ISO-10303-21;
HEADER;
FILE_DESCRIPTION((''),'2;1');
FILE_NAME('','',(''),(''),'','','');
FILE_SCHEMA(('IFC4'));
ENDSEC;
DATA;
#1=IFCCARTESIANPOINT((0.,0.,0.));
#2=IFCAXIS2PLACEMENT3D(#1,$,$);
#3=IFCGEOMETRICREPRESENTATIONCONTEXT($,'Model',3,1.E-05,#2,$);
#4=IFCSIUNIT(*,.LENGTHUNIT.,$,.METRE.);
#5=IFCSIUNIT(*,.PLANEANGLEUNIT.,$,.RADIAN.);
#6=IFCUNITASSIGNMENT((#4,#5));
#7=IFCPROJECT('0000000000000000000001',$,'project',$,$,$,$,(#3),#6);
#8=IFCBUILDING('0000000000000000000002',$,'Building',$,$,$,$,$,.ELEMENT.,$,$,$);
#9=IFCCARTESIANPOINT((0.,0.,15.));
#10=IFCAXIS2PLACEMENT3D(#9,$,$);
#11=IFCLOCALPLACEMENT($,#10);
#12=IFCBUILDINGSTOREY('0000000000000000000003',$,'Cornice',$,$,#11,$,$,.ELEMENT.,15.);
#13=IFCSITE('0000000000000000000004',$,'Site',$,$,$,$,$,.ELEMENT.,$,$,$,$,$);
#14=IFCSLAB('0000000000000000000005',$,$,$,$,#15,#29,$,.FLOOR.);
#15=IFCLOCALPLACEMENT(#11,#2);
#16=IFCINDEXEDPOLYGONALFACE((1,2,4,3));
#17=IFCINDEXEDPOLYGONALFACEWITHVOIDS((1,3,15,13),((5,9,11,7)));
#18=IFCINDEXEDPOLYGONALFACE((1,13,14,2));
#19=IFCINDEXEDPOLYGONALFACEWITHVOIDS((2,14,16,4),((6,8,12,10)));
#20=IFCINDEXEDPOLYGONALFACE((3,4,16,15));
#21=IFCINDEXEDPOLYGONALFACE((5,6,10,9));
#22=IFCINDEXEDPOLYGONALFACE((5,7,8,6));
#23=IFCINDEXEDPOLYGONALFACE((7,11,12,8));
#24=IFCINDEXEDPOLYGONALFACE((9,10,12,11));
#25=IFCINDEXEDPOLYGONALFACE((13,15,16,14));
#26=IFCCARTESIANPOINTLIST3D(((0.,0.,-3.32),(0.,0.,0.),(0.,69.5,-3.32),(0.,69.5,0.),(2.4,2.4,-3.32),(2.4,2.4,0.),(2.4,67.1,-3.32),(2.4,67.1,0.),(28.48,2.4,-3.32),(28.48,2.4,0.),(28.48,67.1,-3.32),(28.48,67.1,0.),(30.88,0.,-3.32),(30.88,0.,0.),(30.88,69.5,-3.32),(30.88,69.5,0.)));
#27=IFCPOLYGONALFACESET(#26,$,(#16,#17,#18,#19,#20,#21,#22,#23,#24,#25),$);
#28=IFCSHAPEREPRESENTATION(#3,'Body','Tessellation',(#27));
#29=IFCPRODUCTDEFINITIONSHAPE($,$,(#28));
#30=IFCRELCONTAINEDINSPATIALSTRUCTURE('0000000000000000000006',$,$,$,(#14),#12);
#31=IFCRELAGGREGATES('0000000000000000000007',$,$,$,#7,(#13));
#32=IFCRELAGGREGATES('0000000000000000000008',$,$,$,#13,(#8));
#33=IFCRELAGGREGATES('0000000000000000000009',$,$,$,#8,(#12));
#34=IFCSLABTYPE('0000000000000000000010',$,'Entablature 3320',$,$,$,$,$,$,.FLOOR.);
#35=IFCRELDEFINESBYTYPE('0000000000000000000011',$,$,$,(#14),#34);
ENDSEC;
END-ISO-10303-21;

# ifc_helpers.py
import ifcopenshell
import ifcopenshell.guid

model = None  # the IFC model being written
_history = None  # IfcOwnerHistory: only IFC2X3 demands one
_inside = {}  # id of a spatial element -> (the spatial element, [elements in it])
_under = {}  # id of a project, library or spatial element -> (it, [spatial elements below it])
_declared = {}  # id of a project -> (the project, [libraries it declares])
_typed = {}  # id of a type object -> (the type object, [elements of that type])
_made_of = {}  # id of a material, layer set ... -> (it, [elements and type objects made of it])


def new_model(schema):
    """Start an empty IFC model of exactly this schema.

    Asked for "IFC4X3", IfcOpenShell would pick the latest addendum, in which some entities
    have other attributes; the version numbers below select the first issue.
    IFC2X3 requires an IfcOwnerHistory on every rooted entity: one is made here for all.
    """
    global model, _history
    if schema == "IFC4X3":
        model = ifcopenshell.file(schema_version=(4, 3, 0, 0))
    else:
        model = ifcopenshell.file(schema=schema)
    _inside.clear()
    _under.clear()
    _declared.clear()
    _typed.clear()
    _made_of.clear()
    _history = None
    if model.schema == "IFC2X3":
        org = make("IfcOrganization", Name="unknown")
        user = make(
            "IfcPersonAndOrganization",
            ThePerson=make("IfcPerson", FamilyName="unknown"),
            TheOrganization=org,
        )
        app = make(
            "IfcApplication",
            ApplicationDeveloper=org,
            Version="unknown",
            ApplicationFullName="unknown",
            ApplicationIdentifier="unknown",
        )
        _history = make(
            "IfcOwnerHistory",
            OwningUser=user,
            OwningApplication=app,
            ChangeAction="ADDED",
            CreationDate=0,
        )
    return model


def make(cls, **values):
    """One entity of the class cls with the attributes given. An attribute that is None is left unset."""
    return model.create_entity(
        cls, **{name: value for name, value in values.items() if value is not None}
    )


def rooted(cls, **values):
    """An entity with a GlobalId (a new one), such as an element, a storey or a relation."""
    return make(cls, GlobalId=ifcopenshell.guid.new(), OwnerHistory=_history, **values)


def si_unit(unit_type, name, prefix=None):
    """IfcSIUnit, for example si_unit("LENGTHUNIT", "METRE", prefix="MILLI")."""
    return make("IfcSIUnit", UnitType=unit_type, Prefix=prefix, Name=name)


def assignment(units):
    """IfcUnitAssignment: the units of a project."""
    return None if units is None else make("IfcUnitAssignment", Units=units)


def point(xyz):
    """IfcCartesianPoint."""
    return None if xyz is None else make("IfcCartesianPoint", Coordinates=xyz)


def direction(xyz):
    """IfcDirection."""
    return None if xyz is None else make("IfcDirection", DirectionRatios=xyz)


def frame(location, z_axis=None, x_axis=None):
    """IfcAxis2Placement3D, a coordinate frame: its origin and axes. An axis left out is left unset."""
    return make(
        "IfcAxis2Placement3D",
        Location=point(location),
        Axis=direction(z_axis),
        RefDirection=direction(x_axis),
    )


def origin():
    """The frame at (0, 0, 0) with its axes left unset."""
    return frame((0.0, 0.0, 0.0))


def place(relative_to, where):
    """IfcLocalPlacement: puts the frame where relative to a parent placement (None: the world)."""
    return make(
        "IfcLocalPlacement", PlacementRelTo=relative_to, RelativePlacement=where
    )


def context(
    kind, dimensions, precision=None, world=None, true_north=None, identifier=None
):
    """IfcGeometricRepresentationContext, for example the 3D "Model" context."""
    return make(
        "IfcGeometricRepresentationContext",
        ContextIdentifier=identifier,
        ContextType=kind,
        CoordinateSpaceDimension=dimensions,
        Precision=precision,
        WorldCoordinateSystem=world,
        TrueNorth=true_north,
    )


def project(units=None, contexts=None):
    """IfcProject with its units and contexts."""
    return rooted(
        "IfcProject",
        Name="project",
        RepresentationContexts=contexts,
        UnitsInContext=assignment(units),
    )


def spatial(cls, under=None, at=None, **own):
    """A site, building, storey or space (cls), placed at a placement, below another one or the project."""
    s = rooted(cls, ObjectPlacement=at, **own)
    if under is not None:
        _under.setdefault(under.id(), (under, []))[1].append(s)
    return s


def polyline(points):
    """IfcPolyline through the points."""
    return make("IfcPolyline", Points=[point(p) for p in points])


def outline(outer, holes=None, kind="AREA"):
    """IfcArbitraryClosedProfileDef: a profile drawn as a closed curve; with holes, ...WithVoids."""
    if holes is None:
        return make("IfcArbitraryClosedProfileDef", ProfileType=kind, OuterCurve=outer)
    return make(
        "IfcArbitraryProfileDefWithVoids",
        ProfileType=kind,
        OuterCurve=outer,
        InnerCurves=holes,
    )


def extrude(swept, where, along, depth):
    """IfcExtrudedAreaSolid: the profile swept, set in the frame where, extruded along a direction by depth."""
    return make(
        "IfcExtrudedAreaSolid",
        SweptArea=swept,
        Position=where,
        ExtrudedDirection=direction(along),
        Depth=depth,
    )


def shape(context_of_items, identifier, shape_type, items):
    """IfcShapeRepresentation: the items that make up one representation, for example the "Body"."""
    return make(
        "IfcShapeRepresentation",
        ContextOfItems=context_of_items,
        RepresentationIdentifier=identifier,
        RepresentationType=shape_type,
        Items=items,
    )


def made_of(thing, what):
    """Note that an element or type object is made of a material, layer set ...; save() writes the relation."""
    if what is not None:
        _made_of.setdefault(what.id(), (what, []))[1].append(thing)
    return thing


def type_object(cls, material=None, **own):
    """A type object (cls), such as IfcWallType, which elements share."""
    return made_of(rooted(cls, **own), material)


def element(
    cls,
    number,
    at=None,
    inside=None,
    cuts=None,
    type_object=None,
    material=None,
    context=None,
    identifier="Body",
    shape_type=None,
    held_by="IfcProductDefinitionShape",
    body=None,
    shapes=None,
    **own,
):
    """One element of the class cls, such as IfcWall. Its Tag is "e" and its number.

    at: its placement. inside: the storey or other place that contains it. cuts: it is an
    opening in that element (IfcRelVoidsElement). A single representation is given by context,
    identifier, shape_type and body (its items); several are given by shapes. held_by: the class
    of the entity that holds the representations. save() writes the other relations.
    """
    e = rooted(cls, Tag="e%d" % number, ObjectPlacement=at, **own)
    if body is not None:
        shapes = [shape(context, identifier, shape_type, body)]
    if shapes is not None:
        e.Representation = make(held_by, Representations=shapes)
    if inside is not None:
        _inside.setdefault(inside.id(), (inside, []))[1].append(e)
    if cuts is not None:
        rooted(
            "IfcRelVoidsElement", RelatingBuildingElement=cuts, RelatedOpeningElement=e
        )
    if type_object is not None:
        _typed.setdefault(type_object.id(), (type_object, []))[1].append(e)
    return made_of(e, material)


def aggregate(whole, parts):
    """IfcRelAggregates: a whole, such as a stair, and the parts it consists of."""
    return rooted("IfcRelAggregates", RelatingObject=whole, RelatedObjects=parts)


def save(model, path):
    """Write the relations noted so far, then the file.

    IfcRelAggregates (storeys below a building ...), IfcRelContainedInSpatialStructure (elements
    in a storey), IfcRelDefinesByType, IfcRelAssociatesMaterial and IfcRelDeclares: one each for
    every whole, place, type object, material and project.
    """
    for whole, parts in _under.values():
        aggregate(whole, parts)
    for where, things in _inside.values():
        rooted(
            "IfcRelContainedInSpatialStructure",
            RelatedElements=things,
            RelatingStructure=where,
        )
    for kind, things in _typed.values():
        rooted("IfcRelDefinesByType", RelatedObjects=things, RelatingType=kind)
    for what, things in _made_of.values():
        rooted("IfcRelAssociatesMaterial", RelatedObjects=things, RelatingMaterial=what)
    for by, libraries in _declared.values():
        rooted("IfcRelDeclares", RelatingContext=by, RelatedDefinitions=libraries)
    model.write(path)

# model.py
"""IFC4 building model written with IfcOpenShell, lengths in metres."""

from ifc_helpers import new_model, si_unit, frame, origin, place, context, project, spatial, polyline, outline, extrude, type_object, element, save


model = new_model("IFC4")

# Units and contexts
model_context = context("Model", 3, precision=1e-05, world=origin())
ifc_project = project(units=[si_unit("LENGTHUNIT", "METRE"), si_unit("PLANEANGLEUNIT", "RADIAN")], contexts=[model_context])

# Site, building, storey
site = spatial("IfcSite", under=ifc_project, Name="Site", CompositionType="ELEMENT")
building = spatial("IfcBuilding", under=site, Name="Building", CompositionType="ELEMENT")
storey_placement = place(None, frame((0.0, 0.0, 15.0)))
storey = spatial("IfcBuildingStorey", under=building, at=storey_placement, Name="Cornice", CompositionType="ELEMENT", Elevation=15.0)

# Slab
slab_type = type_object("IfcSlabType", Name="Entablature 3320", PredefinedType="FLOOR")
slab_placement = place(None, frame((0.0, 0.0, 15.0)))
element("IfcSlab", 1, at=slab_placement, inside=storey, type_object=slab_type, PredefinedType="FLOOR", context=model_context, shape_type="SweptSolid", body=[
    extrude(outline(polyline([(0.0, 0.0), (30.88, 0.0), (30.88, 69.5), (0.0, 69.5), (0.0, 0.0)]), holes=[polyline([(2.4, 2.4), (2.4, 67.1), (28.48, 67.1), (28.48, 2.4), (2.4, 2.4)])]), origin(), (0.0, 0.0, -1.0), 3.32),
])

save(model, "model.ifc")
